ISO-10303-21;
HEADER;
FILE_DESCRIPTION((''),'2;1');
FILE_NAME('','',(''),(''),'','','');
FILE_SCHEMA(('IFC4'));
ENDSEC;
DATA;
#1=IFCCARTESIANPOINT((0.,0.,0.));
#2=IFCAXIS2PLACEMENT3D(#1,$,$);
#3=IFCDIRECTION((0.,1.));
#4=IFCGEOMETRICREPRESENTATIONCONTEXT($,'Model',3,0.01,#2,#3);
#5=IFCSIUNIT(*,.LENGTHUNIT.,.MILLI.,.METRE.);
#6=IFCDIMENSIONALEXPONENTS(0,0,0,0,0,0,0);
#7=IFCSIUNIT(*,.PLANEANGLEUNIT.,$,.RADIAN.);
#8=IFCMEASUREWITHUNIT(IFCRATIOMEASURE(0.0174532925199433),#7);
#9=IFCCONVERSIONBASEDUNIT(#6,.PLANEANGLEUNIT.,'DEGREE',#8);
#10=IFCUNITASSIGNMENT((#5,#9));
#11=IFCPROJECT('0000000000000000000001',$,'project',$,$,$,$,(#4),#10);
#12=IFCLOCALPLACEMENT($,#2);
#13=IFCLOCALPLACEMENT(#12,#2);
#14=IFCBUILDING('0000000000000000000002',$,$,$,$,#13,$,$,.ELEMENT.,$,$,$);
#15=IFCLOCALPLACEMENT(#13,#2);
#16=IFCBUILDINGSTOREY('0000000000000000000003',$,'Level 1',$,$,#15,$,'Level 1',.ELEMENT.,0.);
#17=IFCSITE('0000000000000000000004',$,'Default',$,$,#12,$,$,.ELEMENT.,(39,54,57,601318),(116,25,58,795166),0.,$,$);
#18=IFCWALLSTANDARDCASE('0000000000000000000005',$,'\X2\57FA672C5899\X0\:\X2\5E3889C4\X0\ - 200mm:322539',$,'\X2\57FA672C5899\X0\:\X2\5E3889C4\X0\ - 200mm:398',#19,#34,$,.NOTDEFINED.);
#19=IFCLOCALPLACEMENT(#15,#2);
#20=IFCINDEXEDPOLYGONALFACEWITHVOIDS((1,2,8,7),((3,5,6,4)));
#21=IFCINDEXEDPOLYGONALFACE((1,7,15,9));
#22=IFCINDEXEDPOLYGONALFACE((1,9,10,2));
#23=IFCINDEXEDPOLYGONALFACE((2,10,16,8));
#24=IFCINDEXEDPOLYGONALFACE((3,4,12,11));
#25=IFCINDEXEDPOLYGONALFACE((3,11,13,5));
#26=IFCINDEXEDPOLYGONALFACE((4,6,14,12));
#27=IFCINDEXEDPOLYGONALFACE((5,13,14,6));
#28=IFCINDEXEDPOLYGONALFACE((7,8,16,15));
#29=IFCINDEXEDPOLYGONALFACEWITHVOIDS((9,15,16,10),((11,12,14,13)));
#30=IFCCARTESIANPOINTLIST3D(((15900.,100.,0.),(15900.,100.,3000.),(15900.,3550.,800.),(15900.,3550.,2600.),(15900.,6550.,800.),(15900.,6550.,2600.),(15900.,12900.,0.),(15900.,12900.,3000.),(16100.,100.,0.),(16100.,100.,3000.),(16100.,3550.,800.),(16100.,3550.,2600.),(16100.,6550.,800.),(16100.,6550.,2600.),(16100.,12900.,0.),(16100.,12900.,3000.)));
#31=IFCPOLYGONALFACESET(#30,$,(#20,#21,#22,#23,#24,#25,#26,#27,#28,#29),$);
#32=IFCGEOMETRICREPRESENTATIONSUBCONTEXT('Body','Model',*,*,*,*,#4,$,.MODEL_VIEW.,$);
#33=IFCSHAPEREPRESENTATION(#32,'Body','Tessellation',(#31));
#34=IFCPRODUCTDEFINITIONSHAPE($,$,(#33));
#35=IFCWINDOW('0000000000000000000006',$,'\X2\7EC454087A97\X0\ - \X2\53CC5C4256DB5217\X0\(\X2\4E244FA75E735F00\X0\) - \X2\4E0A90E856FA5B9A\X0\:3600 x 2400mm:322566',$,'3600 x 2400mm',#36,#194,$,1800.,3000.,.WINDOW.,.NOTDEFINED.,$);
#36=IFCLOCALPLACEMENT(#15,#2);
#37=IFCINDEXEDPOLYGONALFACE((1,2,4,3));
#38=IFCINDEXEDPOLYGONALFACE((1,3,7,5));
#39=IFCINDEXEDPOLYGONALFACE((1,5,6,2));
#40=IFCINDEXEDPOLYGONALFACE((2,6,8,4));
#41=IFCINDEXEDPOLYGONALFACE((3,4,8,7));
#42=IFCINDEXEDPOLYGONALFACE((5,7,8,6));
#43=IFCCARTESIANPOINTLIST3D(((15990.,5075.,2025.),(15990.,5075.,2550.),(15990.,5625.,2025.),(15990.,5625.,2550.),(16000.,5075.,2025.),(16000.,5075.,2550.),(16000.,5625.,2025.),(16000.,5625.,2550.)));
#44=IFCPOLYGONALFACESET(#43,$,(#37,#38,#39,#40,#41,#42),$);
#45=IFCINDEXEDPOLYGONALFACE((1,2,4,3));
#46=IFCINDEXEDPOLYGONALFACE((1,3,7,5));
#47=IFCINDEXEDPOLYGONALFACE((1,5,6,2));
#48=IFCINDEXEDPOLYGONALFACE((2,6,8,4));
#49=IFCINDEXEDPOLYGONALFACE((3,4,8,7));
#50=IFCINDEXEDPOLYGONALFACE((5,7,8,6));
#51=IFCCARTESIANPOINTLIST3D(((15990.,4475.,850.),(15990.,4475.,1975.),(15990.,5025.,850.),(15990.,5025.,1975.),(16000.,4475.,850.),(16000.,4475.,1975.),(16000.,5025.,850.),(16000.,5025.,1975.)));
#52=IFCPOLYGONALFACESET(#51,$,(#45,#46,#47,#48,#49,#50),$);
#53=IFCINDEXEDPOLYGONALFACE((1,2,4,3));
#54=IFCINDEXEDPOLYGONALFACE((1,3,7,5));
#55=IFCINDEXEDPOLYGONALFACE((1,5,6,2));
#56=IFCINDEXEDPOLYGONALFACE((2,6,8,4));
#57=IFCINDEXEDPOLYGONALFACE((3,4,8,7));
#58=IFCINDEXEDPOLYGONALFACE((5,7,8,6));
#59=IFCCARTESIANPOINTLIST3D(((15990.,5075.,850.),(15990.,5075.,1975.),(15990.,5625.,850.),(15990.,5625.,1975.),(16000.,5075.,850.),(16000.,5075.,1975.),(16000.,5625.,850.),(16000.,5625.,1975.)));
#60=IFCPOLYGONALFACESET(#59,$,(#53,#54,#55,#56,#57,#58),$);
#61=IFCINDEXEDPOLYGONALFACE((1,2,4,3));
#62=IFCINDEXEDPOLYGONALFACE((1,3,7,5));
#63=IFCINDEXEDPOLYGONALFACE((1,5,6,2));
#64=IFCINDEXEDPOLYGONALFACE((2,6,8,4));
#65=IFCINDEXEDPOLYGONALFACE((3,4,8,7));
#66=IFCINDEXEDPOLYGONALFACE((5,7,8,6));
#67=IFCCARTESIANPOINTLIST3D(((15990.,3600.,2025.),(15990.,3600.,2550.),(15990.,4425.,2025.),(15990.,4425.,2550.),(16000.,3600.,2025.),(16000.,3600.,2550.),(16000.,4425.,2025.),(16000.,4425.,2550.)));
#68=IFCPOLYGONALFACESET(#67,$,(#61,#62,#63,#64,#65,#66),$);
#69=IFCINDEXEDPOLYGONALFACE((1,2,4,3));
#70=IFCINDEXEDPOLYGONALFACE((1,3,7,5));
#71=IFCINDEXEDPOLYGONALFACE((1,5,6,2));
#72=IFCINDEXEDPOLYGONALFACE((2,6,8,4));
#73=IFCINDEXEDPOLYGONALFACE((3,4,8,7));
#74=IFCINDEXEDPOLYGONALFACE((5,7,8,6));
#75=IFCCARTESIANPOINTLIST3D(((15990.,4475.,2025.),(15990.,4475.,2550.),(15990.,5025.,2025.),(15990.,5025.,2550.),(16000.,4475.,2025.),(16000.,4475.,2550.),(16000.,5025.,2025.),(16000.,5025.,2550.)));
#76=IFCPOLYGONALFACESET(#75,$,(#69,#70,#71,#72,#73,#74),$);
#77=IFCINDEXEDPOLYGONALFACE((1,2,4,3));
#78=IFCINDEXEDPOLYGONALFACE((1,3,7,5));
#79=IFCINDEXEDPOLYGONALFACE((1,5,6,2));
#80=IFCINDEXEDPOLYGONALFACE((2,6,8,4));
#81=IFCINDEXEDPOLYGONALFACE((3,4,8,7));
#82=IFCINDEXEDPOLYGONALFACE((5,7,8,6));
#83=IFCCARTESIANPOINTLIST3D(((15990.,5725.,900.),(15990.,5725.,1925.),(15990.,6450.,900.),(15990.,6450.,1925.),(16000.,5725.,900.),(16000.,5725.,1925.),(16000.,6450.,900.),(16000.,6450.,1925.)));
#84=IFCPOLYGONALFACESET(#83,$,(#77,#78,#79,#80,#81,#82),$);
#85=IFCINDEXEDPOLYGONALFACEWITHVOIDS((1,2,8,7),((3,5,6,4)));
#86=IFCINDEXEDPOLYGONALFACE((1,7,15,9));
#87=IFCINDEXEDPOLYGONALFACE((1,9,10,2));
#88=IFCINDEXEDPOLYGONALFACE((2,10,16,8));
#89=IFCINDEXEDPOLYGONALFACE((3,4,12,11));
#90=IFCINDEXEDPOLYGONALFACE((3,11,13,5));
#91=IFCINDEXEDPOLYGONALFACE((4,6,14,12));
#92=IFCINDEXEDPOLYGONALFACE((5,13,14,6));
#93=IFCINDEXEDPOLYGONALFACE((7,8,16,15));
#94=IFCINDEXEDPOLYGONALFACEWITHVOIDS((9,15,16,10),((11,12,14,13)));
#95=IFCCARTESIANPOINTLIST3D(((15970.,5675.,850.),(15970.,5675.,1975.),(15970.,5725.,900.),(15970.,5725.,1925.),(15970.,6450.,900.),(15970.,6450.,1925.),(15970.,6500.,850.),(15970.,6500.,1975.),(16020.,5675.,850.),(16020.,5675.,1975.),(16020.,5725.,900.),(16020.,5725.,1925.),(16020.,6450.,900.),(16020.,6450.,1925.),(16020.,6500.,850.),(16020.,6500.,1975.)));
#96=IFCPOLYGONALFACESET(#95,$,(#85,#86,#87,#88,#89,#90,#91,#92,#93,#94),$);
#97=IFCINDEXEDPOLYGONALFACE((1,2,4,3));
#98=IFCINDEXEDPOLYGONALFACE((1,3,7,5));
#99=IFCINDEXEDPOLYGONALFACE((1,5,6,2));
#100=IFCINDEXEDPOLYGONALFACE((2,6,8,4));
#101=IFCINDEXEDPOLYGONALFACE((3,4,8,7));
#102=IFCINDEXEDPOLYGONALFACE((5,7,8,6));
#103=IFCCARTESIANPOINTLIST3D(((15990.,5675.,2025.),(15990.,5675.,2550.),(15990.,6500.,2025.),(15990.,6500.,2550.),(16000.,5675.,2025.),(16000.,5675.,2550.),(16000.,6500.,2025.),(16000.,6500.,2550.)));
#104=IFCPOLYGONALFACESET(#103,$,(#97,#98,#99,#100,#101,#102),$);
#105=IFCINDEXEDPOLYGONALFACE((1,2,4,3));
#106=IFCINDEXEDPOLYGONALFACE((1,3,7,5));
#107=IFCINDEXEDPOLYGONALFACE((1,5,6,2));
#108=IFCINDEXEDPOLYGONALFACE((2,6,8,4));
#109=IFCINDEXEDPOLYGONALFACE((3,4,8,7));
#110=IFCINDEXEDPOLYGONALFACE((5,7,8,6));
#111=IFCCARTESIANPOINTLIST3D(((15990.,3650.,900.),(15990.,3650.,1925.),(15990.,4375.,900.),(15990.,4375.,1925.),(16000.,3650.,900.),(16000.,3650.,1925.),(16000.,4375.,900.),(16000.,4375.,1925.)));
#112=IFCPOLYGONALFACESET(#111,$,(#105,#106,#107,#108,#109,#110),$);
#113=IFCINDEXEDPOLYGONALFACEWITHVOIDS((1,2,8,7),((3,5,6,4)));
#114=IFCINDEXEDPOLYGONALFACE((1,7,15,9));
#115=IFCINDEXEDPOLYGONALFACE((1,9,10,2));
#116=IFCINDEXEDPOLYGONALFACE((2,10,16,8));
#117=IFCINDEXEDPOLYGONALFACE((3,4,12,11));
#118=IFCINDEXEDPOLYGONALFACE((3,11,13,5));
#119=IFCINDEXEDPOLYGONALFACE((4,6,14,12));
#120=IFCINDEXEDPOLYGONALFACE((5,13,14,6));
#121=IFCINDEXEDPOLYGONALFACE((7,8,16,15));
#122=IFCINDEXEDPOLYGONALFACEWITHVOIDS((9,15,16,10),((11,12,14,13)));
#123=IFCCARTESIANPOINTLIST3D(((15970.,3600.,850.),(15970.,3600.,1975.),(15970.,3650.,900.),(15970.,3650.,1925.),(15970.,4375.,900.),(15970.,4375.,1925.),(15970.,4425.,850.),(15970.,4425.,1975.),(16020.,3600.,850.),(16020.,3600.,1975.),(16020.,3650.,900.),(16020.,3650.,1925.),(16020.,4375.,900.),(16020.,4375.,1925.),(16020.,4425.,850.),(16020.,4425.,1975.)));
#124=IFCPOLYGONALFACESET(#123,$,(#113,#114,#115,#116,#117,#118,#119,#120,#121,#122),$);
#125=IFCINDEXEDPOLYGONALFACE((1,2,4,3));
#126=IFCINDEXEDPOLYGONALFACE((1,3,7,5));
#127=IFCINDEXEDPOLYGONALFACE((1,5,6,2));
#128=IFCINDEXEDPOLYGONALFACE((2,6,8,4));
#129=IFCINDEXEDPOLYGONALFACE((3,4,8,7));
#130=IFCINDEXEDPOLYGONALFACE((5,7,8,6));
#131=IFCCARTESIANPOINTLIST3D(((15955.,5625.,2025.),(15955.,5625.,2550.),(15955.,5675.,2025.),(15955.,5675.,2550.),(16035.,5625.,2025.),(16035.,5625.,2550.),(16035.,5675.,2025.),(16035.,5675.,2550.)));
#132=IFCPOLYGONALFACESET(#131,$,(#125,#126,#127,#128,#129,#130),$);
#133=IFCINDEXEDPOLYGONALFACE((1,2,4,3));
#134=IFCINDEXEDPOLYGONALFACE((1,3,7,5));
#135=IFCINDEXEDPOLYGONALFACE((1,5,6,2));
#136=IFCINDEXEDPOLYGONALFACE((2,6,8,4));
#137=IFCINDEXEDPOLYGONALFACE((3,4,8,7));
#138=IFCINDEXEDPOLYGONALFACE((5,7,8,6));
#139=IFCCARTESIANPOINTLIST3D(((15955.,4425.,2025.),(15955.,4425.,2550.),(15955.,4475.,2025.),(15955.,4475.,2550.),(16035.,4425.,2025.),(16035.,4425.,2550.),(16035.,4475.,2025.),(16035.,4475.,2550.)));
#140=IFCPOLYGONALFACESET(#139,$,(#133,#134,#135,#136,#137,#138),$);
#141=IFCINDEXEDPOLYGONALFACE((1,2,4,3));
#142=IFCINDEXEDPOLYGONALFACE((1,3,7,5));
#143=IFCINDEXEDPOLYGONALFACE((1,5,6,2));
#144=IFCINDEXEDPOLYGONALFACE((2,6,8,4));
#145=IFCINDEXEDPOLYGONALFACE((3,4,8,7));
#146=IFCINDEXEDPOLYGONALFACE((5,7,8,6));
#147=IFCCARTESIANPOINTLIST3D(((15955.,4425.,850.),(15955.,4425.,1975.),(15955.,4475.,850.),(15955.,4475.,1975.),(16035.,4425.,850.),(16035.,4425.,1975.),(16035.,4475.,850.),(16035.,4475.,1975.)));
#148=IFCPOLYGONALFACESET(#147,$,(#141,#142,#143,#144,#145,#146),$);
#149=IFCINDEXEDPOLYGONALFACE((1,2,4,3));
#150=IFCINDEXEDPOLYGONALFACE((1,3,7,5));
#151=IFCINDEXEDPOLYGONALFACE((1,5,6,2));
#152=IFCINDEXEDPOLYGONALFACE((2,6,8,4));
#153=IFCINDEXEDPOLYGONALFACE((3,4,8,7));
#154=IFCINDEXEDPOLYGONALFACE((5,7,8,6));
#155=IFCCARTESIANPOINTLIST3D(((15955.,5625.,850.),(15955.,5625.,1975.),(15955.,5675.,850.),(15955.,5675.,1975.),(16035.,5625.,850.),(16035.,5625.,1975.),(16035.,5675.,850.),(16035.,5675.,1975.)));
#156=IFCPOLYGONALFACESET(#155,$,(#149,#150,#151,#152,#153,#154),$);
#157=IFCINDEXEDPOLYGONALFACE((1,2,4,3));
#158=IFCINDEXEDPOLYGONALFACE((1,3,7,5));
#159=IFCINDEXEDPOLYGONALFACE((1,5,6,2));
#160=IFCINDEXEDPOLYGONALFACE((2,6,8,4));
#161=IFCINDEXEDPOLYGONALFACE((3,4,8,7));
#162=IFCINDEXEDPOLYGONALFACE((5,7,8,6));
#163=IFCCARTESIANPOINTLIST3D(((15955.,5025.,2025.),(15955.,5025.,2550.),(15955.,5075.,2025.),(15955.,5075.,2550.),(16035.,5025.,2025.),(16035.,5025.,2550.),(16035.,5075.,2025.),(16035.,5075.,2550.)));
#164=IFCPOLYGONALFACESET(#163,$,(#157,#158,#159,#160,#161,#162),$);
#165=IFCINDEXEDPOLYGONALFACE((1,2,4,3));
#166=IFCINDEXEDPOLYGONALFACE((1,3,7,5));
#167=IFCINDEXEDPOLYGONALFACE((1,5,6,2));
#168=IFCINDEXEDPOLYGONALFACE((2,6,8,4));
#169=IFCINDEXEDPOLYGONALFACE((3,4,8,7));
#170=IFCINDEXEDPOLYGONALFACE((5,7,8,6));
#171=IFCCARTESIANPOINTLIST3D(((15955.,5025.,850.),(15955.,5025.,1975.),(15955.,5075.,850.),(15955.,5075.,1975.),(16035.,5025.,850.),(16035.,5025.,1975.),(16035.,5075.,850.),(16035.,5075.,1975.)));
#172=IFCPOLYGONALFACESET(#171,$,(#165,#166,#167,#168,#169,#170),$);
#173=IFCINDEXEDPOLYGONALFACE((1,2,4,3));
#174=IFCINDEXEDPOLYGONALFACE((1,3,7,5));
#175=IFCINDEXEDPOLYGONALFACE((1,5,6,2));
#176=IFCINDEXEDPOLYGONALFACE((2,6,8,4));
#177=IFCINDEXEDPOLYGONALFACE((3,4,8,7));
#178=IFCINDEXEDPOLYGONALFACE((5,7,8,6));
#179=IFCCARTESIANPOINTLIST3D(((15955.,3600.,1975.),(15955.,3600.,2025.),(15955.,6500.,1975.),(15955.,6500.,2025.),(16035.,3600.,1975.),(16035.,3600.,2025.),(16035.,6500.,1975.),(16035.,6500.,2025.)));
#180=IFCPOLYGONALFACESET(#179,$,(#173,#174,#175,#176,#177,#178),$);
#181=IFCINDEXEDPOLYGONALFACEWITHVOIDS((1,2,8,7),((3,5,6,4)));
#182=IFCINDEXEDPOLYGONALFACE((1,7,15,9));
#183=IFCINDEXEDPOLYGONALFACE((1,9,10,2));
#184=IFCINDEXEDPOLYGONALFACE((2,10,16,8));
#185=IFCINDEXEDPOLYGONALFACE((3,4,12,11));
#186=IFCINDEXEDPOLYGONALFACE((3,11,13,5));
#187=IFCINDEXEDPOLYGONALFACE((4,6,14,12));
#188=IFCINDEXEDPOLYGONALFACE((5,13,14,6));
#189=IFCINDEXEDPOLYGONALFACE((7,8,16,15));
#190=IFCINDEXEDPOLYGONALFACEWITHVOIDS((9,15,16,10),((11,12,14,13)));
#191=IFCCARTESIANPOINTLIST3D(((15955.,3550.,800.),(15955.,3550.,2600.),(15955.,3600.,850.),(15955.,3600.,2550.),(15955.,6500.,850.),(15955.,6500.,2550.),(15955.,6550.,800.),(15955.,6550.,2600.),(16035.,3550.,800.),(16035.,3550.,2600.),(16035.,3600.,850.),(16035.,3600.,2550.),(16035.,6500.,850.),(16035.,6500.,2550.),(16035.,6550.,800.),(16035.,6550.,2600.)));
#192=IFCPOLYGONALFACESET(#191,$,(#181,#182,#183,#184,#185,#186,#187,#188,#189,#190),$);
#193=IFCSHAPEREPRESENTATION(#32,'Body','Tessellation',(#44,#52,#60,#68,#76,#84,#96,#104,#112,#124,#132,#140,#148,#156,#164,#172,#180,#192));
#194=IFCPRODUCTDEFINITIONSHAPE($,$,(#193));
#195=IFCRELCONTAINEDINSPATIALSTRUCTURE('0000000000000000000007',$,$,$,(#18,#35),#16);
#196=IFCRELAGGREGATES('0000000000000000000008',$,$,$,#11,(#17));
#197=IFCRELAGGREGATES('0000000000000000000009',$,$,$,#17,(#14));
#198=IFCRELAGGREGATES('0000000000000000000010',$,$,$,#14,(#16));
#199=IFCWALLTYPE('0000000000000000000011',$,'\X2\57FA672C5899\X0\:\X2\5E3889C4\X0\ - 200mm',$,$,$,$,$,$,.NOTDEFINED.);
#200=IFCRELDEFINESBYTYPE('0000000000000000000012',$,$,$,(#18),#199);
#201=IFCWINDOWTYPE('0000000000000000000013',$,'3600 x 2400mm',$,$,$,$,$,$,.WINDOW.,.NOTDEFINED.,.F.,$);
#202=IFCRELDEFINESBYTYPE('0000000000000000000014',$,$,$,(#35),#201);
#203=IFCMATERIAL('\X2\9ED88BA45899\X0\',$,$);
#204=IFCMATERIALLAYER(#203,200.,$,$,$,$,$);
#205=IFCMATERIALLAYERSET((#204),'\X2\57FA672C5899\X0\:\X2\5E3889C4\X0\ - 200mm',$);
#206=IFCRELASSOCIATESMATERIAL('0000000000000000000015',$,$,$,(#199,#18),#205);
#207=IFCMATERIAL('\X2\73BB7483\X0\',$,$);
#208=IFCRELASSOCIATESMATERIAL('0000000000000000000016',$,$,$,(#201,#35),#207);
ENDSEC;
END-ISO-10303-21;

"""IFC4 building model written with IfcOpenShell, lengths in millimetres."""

from ifc_helpers import new_model, entity, si_unit, converted_unit, direction, frame, frame_2d, origin, origin_2d_with_axis, place, context, subcontext, project, spatial, polyline, rectangle, outline, extrude, source, transform, mapped, material, layer, layer_set, layer_usage, type_object, type_shapes, element, fill, save


model = new_model("IFC4")

# Units and contexts
model_context = context("Model", 3, precision=0.01, world=origin(), true_north=direction((0.0, 1.0)))
body_context = subcontext(model_context, "Body", "Model", "MODEL_VIEW")
ifc_project = project(units=[si_unit("LENGTHUNIT", "METRE", prefix="MILLI"), converted_unit("PLANEANGLEUNIT", "DEGREE", entity("IfcRatioMeasure", 0.0174532925199433), si_unit("PLANEANGLEUNIT", "RADIAN"), dimensions=[0, 0, 0, 0, 0, 0, 0])], contexts=[model_context])

# Site, building, storey
site_placement = place(None, origin())
site = spatial("IfcSite", under=ifc_project, at=site_placement, Name="Default", CompositionType="ELEMENT", RefLatitude=(39, 54, 57, 601318), RefLongitude=(116, 25, 58, 795166), RefElevation=0.0)
building_placement = place(site_placement, origin())
building = spatial("IfcBuilding", under=site, at=building_placement, CompositionType="ELEMENT")
storey_placement = place(building_placement, origin())
storey = spatial("IfcBuildingStorey", under=building, at=storey_placement, Name="Level 1", LongName="Level 1", CompositionType="ELEMENT", Elevation=0.0)

# Shared definitions
ifc_material_1 = material(Name="默认墙")
ifc_layer_1 = layer(ifc_material_1, 200.0)
ifc_layer_set_1 = layer_set([ifc_layer_1], Name="基本墙:常规 - 200mm")
wall_type = type_object("IfcWallType", Name="基本墙:常规 - 200mm", PredefinedType="NOTDEFINED", material=ifc_layer_set_1)
ifc_material_2 = material(Name="玻璃")
window_type_1 = type_object("IfcWindowType", Name="3600 x 2400mm", ParameterTakesPrecedence=False, PartitioningType="NOTDEFINED", PredefinedType="WINDOW", material=ifc_material_2)
shared_shape_1 = source(origin(), body_context, "Body", "SweptSolid", [
    extrude(rectangle(XDim=10.0, YDim=550.0, at=origin_2d_with_axis()), frame((1200.0, 95.0, 1225.0), z_axis=(0.0, 0.0, 1.0), x_axis=(0.0, 1.0, 0.0)), (0.0, 0.0, 1.0), 525.0),
    extrude(rectangle(XDim=10.0, YDim=550.0, at=origin_2d_with_axis()), frame((1800.0, 95.0, 50.0), z_axis=(0.0, 0.0, 1.0), x_axis=(0.0, 1.0, 0.0)), (0.0, 0.0, 1.0), 1125.0),
    extrude(rectangle(XDim=10.0, YDim=550.0, at=origin_2d_with_axis()), frame((1200.0, 95.0, 50.0), z_axis=(0.0, 0.0, 1.0), x_axis=(0.0, 1.0, 0.0)), (0.0, 0.0, 1.0), 1125.0),
    extrude(rectangle(XDim=10.0, YDim=825.0, at=origin_2d_with_axis()), frame((2537.5, 95.0, 1225.0), z_axis=(0.0, 0.0, 1.0), x_axis=(0.0, 1.0, 0.0)), (0.0, 0.0, 1.0), 525.0),
    extrude(rectangle(XDim=10.0, YDim=550.0, at=origin_2d_with_axis()), frame((1800.0, 95.0, 1225.0), z_axis=(0.0, 0.0, 1.0), x_axis=(0.0, 1.0, 0.0)), (0.0, 0.0, 1.0), 525.0),
    extrude(rectangle(XDim=10.0, YDim=725.0, at=origin_2d_with_axis()), frame((462.5, 95.0, 100.0), z_axis=(0.0, 0.0, 1.0), x_axis=(0.0, 1.0, 0.0)), (0.0, 0.0, 1.0), 1025.0),
    extrude(outline(polyline([(-562.5, -412.5), (562.5, -412.5), (562.5, 412.5), (-562.5, 412.5), (-562.5, -412.5)]), holes=[polyline([(512.5, -362.5), (-512.5, -362.5), (-512.5, 362.5), (512.5, 362.5), (512.5, -362.5)])]), frame((462.5, 70.0, 612.5), z_axis=(0.0, 1.0, 0.0), x_axis=(0.0, 0.0, -1.0)), (0.0, 0.0, 1.0), 50.0),
    extrude(rectangle(XDim=10.0, YDim=825.0, at=origin_2d_with_axis()), frame((462.5, 95.0, 1225.0), z_axis=(0.0, 0.0, 1.0), x_axis=(0.0, 1.0, 0.0)), (0.0, 0.0, 1.0), 525.0),
    extrude(rectangle(XDim=10.0, YDim=725.0, at=origin_2d_with_axis()), frame((2537.5, 95.0, 100.0), z_axis=(0.0, 0.0, 1.0), x_axis=(0.0, 1.0, 0.0)), (0.0, 0.0, 1.0), 1025.0),
    extrude(outline(polyline([(-562.5, -412.5), (562.5, -412.5), (562.5, 412.5), (-562.5, 412.5), (-562.5, -412.5)]), holes=[polyline([(512.5, -362.5), (-512.5, -362.5), (-512.5, 362.5), (512.5, 362.5), (512.5, -362.5)])]), frame((2537.5, 70.0, 612.5), z_axis=(0.0, 1.0, 0.0), x_axis=(0.0, 0.0, -1.0)), (0.0, 0.0, 1.0), 50.0),
    extrude(rectangle(XDim=80.0, YDim=50.0, at=origin_2d_with_axis()), frame((900.0, 95.0, 1225.0), z_axis=(0.0, 0.0, 1.0), x_axis=(0.0, -1.0, 0.0)), (0.0, 0.0, 1.0), 525.0),
    extrude(rectangle(XDim=80.0, YDim=50.0, at=origin_2d_with_axis()), frame((2100.0, 95.0, 1225.0), z_axis=(0.0, 0.0, 1.0), x_axis=(0.0, -1.0, 0.0)), (0.0, 0.0, 1.0), 525.0),
    extrude(rectangle(XDim=80.0, YDim=50.0, at=origin_2d_with_axis()), frame((2100.0, 95.0, 50.0), z_axis=(0.0, 0.0, 1.0), x_axis=(0.0, -1.0, 0.0)), (0.0, 0.0, 1.0), 1125.0),
    extrude(rectangle(XDim=80.0, YDim=50.0, at=origin_2d_with_axis()), frame((900.0, 95.0, 50.0), z_axis=(0.0, 0.0, 1.0), x_axis=(0.0, -1.0, 0.0)), (0.0, 0.0, 1.0), 1125.0),
    extrude(rectangle(XDim=80.0, YDim=50.0, at=origin_2d_with_axis()), frame((1500.0, 95.0, 1225.0), z_axis=(0.0, 0.0, 1.0), x_axis=(0.0, -1.0, 0.0)), (0.0, 0.0, 1.0), 525.0),
    extrude(rectangle(XDim=80.0, YDim=50.0, at=origin_2d_with_axis()), frame((1500.0, 95.0, 50.0), z_axis=(0.0, 0.0, 1.0), x_axis=(0.0, -1.0, 0.0)), (0.0, 0.0, 1.0), 1125.0),
    extrude(rectangle(XDim=80.0, YDim=2900.0, at=origin_2d_with_axis()), frame((1500.0, 95.0, 1175.0), z_axis=(0.0, 0.0, 1.0), x_axis=(0.0, -1.0, 0.0)), (0.0, 0.0, 1.0), 50.0),
    extrude(outline(polyline([(-1500.0, -900.0), (1500.0, -900.0), (1500.0, 900.0), (-1500.0, 900.0), (-1500.0, -900.0)]), holes=[polyline([(1450.0, -850.0), (-1450.0, -850.0), (-1450.0, 850.0), (1450.0, 850.0), (1450.0, -850.0)])]), frame((1500.0, 55.0, 900.0), z_axis=(0.0, 1.0, 0.0), x_axis=(1.0, 0.0, 0.0)), (0.0, 0.0, 1.0), 80.0),
])
type_shapes(window_type_1, [shared_shape_1])

# Wall, opening, window
ifc_layer_usage_1 = layer_usage(ifc_layer_set_1, "AXIS2", "NEGATIVE", 100.0)
wall_1_placement = place(storey_placement, frame((16000.0, 12900.0, 0.0), z_axis=(0.0, 0.0, 1.0), x_axis=(0.0, -1.0, 0.0)))
wall_1 = element("IfcWallStandardCase", 1, at=wall_1_placement, inside=storey, type_object=wall_type, material=ifc_layer_usage_1, Name="基本墙:常规 - 200mm:322539", ObjectType="基本墙:常规 - 200mm:398", PredefinedType="NOTDEFINED", context=body_context, shape_type="SweptSolid", body=[
    extrude(rectangle(XDim=12800.0, YDim=200.0, at=frame_2d((6400.0, 0.0), x_axis=(-1.0, 0.0))), origin(), (0.0, 0.0, 1.0), 3000.0),
])
opening_1_placement = place(wall_1_placement, frame((6350.0, -100.0, 800.0)))
opening_1 = element("IfcOpeningElement", 2, at=opening_1_placement, cuts=wall_1, ObjectType="Opening", PredefinedType="OPENING", context=body_context, shape_type="SweptSolid", body=[
    extrude(rectangle(XDim=1800.0, YDim=3000.0, at=frame_2d((900.0, 1500.0), x_axis=(1.0, 0.0))), frame((0.0, 0.0, 0.0), z_axis=(0.0, 1.0, 0.0), x_axis=(0.0, 0.0, 1.0)), (0.0, 0.0, 1.0), 200.0),
])
window_1_placement = place(opening_1_placement, origin())
window_1 = element("IfcWindow", 3, at=window_1_placement, inside=storey, type_object=window_type_1, material=ifc_material_2, Name="组合窗 - 双层四列(两侧平开) - 上部固定:3600 x 2400mm:322566", ObjectType="3600 x 2400mm", OverallHeight=1800.0, OverallWidth=3000.0, PartitioningType="NOTDEFINED", PredefinedType="WINDOW", context=body_context, shape_type="MappedRepresentation", body=[
    mapped(shared_shape_1, transform((0.0, 0.0, 0.0), scale=1.0)),
])
fill(opening_1, window_1)

save(model, "model.ifc")
